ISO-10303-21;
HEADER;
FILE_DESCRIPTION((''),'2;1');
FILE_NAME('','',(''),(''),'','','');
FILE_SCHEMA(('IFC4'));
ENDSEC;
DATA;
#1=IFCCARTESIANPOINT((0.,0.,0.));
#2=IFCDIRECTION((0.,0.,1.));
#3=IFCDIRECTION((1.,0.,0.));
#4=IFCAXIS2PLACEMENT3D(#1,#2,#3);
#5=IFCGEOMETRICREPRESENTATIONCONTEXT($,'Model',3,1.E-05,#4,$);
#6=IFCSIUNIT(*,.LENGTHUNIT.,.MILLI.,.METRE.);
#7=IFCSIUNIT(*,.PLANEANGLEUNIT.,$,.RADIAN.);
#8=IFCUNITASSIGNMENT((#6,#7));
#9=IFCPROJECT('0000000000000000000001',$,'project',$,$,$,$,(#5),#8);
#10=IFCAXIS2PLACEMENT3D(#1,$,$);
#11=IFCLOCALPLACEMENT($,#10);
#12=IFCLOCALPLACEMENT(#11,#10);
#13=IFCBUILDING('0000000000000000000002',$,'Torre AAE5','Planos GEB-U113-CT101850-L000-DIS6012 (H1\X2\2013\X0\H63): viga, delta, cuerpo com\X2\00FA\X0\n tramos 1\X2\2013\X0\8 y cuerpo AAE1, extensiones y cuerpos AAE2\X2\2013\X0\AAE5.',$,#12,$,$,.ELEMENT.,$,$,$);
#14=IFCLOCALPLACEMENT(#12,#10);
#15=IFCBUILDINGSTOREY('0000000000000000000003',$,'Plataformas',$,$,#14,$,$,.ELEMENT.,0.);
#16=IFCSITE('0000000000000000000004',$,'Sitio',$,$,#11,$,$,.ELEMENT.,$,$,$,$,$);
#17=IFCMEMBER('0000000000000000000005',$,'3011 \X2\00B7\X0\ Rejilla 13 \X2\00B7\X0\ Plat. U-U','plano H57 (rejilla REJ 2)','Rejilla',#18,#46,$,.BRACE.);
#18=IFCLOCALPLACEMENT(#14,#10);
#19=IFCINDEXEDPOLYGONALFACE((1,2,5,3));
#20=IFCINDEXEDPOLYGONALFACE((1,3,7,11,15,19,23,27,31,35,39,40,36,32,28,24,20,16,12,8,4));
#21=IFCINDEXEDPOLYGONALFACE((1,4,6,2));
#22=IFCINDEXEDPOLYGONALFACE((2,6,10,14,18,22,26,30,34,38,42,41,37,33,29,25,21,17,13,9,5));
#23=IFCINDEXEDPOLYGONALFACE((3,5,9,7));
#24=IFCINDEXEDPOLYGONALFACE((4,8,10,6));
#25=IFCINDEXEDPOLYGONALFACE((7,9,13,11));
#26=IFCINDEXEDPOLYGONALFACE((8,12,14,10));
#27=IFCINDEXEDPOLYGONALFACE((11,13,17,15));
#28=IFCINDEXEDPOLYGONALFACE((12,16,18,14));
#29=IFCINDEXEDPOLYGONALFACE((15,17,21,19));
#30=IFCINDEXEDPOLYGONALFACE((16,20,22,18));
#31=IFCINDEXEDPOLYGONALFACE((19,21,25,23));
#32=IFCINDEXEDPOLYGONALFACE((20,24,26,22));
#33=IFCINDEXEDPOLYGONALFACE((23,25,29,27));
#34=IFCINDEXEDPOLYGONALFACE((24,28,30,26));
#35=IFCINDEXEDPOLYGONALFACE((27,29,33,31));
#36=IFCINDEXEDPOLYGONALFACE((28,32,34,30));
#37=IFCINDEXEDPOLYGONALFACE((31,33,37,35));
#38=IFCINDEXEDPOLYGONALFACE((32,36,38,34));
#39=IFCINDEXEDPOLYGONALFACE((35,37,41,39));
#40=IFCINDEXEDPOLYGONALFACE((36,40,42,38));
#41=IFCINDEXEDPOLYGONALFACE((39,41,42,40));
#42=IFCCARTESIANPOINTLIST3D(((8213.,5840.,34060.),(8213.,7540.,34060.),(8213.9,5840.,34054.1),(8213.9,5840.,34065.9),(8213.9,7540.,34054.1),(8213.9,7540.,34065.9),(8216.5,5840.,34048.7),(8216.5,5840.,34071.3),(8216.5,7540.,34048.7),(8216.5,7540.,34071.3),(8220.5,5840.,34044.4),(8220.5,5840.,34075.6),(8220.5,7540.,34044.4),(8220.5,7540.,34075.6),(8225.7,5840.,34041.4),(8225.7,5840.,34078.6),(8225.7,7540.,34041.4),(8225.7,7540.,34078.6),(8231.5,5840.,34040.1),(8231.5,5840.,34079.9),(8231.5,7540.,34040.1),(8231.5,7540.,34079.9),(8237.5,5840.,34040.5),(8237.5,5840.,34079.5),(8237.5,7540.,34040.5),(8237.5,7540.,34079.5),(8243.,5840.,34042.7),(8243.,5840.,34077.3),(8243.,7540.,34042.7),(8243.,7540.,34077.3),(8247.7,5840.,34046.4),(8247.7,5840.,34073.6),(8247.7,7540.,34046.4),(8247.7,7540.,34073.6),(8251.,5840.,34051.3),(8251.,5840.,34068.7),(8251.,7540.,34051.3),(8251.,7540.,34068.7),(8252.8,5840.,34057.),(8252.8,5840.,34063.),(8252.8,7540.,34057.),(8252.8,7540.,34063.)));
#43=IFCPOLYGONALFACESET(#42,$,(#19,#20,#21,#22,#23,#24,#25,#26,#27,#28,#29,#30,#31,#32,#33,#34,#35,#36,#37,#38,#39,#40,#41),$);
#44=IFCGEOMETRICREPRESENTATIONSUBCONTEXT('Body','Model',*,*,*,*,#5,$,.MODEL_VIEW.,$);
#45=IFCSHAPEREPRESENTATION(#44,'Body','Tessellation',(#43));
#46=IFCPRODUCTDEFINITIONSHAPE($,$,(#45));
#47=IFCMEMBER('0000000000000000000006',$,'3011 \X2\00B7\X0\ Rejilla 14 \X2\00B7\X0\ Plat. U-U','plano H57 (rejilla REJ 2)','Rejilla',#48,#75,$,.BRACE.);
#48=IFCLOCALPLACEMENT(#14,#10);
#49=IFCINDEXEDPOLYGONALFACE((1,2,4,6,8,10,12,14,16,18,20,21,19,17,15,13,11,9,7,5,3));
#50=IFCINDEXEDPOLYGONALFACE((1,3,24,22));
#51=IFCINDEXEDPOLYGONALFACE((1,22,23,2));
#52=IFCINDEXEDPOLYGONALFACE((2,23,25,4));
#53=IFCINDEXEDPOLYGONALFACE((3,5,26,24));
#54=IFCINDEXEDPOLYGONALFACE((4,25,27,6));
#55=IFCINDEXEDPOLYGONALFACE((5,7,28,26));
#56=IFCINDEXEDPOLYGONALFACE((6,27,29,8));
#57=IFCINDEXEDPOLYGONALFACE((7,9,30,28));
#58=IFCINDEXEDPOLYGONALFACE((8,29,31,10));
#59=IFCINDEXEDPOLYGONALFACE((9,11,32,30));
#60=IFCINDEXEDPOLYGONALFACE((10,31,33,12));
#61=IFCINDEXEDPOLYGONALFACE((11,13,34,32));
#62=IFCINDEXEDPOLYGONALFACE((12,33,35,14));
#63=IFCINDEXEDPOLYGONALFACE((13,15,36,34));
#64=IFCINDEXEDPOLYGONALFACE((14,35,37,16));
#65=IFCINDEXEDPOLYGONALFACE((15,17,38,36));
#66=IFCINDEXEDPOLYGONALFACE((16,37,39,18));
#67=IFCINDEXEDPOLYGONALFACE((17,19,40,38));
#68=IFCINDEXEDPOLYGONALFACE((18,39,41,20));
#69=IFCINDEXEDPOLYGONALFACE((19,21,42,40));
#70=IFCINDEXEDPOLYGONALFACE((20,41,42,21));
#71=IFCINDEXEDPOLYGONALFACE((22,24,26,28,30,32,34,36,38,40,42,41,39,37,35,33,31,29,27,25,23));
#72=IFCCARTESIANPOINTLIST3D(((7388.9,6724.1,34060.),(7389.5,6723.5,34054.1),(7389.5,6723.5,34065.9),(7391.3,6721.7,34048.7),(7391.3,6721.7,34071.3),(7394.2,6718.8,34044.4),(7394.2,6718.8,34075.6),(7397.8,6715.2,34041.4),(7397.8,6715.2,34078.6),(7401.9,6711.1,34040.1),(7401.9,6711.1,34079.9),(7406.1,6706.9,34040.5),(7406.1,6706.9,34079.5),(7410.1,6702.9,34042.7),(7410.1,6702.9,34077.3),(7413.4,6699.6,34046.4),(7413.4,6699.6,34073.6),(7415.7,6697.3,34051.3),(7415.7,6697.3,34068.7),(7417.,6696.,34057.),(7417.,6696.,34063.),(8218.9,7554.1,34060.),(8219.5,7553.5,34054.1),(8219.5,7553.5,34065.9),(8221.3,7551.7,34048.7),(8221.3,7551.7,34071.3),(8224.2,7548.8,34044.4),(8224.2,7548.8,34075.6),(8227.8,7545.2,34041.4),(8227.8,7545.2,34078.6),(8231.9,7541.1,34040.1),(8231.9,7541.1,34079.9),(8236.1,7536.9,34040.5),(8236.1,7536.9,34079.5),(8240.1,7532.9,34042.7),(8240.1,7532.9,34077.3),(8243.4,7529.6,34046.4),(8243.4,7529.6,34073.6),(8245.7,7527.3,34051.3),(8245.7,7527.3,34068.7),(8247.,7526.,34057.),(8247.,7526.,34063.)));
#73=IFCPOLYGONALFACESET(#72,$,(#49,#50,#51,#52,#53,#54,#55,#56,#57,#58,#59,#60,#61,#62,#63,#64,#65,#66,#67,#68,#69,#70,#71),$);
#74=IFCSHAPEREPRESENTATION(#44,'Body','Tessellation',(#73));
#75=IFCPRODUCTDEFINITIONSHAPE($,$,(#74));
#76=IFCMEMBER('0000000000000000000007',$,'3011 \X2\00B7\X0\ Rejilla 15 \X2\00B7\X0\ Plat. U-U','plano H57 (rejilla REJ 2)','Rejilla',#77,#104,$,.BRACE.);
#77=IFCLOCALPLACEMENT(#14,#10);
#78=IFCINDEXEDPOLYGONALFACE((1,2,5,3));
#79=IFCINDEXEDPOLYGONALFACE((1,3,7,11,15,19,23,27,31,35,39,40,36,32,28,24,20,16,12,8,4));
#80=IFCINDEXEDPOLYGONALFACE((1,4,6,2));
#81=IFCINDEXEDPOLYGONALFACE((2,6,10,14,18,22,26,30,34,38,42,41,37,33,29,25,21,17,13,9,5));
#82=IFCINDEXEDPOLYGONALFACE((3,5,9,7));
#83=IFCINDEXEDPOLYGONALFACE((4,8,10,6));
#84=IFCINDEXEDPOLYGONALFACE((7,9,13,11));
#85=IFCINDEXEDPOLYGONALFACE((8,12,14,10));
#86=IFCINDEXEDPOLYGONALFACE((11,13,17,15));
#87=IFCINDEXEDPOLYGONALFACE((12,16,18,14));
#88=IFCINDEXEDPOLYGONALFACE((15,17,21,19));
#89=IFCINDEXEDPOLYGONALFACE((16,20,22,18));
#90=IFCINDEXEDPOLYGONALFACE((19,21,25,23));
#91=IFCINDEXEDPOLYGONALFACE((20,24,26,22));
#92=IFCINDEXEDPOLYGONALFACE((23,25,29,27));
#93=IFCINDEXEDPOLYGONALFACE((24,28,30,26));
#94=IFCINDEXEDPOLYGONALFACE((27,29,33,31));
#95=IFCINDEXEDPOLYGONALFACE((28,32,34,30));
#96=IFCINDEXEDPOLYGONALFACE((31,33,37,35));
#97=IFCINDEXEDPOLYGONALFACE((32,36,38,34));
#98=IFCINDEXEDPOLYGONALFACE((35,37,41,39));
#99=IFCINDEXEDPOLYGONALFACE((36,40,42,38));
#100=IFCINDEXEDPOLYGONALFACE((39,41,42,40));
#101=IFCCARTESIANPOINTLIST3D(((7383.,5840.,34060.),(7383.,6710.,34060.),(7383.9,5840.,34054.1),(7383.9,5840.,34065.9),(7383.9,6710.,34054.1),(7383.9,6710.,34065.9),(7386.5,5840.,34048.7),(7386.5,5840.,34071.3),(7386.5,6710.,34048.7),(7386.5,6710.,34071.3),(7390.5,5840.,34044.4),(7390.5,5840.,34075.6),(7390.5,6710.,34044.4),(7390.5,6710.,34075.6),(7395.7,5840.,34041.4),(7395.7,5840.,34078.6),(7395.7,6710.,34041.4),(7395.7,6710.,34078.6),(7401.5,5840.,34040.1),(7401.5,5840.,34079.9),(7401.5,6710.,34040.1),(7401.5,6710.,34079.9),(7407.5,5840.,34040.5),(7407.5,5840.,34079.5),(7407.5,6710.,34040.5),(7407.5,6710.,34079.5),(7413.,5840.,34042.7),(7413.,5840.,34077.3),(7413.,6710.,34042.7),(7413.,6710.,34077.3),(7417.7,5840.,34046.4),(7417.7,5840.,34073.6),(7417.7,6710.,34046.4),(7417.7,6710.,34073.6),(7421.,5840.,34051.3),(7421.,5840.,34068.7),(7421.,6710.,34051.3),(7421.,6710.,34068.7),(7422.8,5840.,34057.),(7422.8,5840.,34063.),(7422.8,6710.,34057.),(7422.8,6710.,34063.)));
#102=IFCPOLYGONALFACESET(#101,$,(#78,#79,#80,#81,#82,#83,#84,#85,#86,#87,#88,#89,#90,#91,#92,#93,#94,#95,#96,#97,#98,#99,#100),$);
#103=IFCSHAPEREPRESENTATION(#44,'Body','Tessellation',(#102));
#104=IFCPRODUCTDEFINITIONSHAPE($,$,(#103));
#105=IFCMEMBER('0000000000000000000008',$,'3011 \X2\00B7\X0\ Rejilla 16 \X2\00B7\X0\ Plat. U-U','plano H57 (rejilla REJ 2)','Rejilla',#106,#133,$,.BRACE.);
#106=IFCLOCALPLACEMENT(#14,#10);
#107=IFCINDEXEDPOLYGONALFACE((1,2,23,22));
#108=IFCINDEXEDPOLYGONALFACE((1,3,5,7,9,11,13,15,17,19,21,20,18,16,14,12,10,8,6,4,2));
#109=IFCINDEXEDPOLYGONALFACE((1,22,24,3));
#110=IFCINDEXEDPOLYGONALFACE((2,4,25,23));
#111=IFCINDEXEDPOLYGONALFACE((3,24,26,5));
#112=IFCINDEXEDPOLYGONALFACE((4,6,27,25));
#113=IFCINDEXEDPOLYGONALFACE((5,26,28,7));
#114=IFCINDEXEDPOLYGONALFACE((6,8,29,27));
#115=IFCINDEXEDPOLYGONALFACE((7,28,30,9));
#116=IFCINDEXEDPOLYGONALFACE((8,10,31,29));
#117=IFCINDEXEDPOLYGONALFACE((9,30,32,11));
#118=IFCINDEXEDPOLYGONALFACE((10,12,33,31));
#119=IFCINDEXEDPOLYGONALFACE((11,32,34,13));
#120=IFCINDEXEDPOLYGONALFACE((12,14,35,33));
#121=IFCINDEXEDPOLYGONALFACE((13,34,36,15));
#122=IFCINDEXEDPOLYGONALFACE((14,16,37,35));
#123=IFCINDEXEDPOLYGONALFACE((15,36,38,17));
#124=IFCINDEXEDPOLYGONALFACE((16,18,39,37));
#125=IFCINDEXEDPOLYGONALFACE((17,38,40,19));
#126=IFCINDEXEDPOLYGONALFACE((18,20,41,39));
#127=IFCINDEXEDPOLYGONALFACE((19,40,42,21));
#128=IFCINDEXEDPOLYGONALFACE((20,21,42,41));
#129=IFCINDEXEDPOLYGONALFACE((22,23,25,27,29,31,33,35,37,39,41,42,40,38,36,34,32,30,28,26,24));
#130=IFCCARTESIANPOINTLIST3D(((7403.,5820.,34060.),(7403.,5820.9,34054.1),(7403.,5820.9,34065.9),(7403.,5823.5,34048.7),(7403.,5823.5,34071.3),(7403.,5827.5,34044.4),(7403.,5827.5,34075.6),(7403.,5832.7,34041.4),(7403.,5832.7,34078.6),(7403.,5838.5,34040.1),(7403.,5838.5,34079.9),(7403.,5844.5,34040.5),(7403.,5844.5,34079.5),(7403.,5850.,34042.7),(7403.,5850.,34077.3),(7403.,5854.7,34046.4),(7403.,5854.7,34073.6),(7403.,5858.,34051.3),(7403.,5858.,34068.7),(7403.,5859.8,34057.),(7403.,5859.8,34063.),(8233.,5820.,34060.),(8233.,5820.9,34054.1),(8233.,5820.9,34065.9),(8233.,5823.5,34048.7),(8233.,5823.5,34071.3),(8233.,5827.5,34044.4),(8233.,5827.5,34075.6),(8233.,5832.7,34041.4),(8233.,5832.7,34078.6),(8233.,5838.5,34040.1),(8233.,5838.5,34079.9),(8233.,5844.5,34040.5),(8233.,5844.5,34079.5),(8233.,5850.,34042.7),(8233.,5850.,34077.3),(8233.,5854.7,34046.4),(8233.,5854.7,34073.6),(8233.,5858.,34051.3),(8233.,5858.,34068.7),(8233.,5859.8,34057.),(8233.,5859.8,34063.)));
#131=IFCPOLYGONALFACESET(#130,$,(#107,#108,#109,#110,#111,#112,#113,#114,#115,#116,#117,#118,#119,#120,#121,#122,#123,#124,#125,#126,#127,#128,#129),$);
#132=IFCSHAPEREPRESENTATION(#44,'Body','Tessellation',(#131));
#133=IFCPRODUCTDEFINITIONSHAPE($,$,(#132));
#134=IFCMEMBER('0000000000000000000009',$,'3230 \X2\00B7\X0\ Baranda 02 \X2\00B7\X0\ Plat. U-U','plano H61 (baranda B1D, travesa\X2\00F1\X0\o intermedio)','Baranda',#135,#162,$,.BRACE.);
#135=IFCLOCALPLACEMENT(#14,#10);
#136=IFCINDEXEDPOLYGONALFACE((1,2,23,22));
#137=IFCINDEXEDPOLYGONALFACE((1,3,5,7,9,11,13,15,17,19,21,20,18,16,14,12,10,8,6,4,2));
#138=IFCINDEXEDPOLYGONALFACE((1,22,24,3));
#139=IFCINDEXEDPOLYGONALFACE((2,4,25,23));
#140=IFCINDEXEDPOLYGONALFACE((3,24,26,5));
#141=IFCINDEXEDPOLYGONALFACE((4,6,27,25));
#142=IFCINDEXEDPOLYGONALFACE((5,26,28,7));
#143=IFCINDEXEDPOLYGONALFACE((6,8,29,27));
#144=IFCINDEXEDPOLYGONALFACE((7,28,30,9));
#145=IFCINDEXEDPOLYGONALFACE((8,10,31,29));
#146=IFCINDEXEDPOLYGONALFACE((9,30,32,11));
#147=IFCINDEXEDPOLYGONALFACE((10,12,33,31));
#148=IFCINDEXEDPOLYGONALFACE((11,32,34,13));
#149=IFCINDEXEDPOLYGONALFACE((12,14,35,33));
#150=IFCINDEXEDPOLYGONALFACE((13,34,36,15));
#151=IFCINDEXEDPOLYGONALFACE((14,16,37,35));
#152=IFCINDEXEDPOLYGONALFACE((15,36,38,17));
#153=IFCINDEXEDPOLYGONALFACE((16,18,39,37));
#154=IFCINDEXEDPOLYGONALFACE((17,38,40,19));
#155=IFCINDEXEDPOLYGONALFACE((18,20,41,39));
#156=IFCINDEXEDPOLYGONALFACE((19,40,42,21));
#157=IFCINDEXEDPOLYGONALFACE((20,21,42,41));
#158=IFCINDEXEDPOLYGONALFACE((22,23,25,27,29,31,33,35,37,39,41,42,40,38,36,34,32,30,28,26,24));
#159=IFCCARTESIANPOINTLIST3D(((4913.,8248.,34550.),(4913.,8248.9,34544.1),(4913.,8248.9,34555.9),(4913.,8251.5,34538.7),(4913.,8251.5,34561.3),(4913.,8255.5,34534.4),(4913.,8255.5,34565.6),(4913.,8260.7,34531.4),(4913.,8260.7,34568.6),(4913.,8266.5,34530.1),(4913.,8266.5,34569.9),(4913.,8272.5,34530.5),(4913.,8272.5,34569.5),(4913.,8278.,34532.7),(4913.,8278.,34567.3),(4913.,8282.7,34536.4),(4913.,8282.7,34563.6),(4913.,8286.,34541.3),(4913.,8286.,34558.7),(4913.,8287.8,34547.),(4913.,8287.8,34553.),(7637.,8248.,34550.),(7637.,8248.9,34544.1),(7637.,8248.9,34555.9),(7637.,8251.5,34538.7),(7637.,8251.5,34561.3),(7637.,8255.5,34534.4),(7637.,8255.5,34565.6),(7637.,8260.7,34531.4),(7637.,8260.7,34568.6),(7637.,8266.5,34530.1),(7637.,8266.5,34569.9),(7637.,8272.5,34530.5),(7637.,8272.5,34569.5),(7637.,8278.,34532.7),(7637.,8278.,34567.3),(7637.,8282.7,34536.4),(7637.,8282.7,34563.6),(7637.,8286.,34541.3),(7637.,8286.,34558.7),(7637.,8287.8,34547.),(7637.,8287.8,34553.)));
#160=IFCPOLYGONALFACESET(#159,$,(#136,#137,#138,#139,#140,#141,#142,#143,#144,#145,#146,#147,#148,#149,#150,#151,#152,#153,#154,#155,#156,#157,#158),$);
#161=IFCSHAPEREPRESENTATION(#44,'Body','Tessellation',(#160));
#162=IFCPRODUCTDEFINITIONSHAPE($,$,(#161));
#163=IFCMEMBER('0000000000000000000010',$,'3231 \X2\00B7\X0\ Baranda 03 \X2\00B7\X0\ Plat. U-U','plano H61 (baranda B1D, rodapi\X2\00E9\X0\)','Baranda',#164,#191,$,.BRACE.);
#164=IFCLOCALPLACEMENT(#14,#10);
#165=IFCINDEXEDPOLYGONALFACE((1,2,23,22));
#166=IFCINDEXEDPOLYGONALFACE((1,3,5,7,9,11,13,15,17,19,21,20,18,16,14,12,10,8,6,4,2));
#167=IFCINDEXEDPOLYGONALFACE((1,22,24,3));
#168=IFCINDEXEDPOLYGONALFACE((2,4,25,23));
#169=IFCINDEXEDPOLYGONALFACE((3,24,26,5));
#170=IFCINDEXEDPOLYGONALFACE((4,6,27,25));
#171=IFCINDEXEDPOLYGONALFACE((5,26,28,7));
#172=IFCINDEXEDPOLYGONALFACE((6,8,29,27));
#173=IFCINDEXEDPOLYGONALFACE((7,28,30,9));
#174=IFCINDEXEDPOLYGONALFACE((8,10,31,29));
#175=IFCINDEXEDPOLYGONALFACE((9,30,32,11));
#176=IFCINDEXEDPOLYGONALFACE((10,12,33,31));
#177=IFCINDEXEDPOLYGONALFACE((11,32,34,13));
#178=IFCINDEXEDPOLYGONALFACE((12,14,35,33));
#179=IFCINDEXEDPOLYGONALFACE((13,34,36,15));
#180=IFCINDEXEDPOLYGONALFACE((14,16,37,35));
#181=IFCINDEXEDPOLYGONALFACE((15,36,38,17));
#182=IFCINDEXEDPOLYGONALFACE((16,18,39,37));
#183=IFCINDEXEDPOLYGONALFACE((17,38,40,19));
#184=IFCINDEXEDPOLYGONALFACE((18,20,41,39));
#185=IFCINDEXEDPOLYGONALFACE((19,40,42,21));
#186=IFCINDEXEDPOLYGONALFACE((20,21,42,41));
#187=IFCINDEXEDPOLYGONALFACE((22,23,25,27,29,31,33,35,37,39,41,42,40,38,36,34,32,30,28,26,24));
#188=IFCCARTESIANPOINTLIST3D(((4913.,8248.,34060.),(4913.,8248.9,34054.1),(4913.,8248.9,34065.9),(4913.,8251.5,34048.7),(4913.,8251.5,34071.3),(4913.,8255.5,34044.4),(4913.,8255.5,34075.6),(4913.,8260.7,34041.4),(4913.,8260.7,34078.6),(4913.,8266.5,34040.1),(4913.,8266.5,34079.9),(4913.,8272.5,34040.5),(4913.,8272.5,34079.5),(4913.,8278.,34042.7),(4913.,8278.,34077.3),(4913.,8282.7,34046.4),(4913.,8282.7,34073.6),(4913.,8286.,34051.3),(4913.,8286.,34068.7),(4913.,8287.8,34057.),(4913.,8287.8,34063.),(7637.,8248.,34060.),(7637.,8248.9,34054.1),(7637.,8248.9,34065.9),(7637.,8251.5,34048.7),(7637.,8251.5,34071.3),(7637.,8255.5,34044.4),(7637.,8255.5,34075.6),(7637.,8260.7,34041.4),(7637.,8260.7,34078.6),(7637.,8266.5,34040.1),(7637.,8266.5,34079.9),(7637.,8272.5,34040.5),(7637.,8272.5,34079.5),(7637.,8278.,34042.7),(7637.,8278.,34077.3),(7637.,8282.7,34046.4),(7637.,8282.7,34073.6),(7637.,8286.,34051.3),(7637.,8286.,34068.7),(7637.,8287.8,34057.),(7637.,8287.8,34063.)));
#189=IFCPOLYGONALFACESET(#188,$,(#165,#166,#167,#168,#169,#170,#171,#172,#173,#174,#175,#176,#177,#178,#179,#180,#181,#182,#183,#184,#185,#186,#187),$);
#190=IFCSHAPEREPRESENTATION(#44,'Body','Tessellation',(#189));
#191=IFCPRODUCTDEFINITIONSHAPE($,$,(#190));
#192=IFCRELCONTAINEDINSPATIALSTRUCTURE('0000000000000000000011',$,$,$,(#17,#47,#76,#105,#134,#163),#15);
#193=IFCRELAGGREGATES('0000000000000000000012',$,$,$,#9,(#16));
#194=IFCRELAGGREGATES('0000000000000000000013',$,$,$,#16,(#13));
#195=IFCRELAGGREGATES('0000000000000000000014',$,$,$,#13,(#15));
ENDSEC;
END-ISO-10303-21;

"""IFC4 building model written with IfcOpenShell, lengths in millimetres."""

from ifc_helpers import new_model, si_unit, frame, origin, origin_with_axes, place, context, subcontext, project, spatial, circle, extrude, element, save


model = new_model("IFC4")

# Units and contexts
model_context = context("Model", 3, precision=1e-05, world=origin_with_axes())
body_context = subcontext(model_context, "Body", "Model", "MODEL_VIEW")
ifc_project = project(units=[si_unit("LENGTHUNIT", "METRE", prefix="MILLI"), si_unit("PLANEANGLEUNIT", "RADIAN")], contexts=[model_context])

# Site, building, storey
site_placement = place(None, origin())
site = spatial("IfcSite", under=ifc_project, at=site_placement, Name="Sitio", CompositionType="ELEMENT")
building_placement = place(site_placement, origin())
building = spatial("IfcBuilding", under=site, at=building_placement, Name="Torre AAE5", Description="Planos GEB-U113-CT101850-L000-DIS6012 (H1–H63): viga, delta, cuerpo común tramos 1–8 y cuerpo AAE1, extensiones y cuerpos AAE2–AAE5.", CompositionType="ELEMENT")
storey_placement = place(building_placement, origin())
storey = spatial("IfcBuildingStorey", under=building, at=storey_placement, Name="Plataformas", CompositionType="ELEMENT", Elevation=0.0)

# Members
member_1_placement = place(storey_placement, frame((8233.0, 5840.0, 34060.0), z_axis=(0.0, 1.0, 0.0), x_axis=(-1.0, 0.0, 0.0)))
element("IfcMember", 1, at=member_1_placement, inside=storey, Name="3011 · Rejilla 13 · Plat. U-U", Description="plano H57 (rejilla REJ 2)", ObjectType="Rejilla", PredefinedType="BRACE", context=body_context, shape_type="SweptSolid", body=[
    extrude(circle(Radius=20.0), None, (0.0, 0.0, 1.0), 1700.0),
])
member_2_placement = place(storey_placement, frame((8233.0, 7540.0, 34060.0), z_axis=(-0.707107, -0.707107, 0.0), x_axis=(-0.707107, 0.707107, 0.0)))
element("IfcMember", 2, at=member_2_placement, inside=storey, Name="3011 · Rejilla 14 · Plat. U-U", Description="plano H57 (rejilla REJ 2)", ObjectType="Rejilla", PredefinedType="BRACE", context=body_context, shape_type="SweptSolid", body=[
    extrude(circle(Radius=20.0), None, (0.0, 0.0, 1.0), 1173.8),
])
member_3_placement = place(storey_placement, frame((7403.0, 6710.0, 34060.0), z_axis=(0.0, -1.0, 0.0), x_axis=(-1.0, 0.0, 0.0)))
element("IfcMember", 3, at=member_3_placement, inside=storey, Name="3011 · Rejilla 15 · Plat. U-U", Description="plano H57 (rejilla REJ 2)", ObjectType="Rejilla", PredefinedType="BRACE", context=body_context, shape_type="SweptSolid", body=[
    extrude(circle(Radius=20.0), None, (0.0, 0.0, 1.0), 870.0),
])
member_4_placement = place(storey_placement, frame((7403.0, 5840.0, 34060.0), z_axis=(1.0, 0.0, 0.0), x_axis=(0.0, -1.0, 0.0)))
element("IfcMember", 4, at=member_4_placement, inside=storey, Name="3011 · Rejilla 16 · Plat. U-U", Description="plano H57 (rejilla REJ 2)", ObjectType="Rejilla", PredefinedType="BRACE", context=body_context, shape_type="SweptSolid", body=[
    extrude(circle(Radius=20.0), None, (0.0, 0.0, 1.0), 830.0),
])
for number, where, z_axis, x_axis, name, description in (
    (5, (7637.0, 8268.0, 34550.0), (-1.0, 0.0, 0.0), (0.0, -1.0, 0.0), "3230 · Baranda 02 · Plat. U-U", "plano H61 (baranda B1D, travesaño intermedio)"),
    (6, (7637.0, 8268.0, 34060.0), (-1.0, 0.0, 0.0), (0.0, -1.0, 0.0), "3231 · Baranda 03 · Plat. U-U", "plano H61 (baranda B1D, rodapié)"),
):
    element("IfcMember", number, at=place(storey_placement, frame(where, z_axis=z_axis, x_axis=x_axis)), inside=storey, Name=name, Description=description, ObjectType="Baranda", PredefinedType="BRACE", context=body_context, shape_type="SweptSolid", body=[
        extrude(circle(Radius=20.0), None, (0.0, 0.0, 1.0), 2724.0),
    ])

save(model, "model.ifc")
